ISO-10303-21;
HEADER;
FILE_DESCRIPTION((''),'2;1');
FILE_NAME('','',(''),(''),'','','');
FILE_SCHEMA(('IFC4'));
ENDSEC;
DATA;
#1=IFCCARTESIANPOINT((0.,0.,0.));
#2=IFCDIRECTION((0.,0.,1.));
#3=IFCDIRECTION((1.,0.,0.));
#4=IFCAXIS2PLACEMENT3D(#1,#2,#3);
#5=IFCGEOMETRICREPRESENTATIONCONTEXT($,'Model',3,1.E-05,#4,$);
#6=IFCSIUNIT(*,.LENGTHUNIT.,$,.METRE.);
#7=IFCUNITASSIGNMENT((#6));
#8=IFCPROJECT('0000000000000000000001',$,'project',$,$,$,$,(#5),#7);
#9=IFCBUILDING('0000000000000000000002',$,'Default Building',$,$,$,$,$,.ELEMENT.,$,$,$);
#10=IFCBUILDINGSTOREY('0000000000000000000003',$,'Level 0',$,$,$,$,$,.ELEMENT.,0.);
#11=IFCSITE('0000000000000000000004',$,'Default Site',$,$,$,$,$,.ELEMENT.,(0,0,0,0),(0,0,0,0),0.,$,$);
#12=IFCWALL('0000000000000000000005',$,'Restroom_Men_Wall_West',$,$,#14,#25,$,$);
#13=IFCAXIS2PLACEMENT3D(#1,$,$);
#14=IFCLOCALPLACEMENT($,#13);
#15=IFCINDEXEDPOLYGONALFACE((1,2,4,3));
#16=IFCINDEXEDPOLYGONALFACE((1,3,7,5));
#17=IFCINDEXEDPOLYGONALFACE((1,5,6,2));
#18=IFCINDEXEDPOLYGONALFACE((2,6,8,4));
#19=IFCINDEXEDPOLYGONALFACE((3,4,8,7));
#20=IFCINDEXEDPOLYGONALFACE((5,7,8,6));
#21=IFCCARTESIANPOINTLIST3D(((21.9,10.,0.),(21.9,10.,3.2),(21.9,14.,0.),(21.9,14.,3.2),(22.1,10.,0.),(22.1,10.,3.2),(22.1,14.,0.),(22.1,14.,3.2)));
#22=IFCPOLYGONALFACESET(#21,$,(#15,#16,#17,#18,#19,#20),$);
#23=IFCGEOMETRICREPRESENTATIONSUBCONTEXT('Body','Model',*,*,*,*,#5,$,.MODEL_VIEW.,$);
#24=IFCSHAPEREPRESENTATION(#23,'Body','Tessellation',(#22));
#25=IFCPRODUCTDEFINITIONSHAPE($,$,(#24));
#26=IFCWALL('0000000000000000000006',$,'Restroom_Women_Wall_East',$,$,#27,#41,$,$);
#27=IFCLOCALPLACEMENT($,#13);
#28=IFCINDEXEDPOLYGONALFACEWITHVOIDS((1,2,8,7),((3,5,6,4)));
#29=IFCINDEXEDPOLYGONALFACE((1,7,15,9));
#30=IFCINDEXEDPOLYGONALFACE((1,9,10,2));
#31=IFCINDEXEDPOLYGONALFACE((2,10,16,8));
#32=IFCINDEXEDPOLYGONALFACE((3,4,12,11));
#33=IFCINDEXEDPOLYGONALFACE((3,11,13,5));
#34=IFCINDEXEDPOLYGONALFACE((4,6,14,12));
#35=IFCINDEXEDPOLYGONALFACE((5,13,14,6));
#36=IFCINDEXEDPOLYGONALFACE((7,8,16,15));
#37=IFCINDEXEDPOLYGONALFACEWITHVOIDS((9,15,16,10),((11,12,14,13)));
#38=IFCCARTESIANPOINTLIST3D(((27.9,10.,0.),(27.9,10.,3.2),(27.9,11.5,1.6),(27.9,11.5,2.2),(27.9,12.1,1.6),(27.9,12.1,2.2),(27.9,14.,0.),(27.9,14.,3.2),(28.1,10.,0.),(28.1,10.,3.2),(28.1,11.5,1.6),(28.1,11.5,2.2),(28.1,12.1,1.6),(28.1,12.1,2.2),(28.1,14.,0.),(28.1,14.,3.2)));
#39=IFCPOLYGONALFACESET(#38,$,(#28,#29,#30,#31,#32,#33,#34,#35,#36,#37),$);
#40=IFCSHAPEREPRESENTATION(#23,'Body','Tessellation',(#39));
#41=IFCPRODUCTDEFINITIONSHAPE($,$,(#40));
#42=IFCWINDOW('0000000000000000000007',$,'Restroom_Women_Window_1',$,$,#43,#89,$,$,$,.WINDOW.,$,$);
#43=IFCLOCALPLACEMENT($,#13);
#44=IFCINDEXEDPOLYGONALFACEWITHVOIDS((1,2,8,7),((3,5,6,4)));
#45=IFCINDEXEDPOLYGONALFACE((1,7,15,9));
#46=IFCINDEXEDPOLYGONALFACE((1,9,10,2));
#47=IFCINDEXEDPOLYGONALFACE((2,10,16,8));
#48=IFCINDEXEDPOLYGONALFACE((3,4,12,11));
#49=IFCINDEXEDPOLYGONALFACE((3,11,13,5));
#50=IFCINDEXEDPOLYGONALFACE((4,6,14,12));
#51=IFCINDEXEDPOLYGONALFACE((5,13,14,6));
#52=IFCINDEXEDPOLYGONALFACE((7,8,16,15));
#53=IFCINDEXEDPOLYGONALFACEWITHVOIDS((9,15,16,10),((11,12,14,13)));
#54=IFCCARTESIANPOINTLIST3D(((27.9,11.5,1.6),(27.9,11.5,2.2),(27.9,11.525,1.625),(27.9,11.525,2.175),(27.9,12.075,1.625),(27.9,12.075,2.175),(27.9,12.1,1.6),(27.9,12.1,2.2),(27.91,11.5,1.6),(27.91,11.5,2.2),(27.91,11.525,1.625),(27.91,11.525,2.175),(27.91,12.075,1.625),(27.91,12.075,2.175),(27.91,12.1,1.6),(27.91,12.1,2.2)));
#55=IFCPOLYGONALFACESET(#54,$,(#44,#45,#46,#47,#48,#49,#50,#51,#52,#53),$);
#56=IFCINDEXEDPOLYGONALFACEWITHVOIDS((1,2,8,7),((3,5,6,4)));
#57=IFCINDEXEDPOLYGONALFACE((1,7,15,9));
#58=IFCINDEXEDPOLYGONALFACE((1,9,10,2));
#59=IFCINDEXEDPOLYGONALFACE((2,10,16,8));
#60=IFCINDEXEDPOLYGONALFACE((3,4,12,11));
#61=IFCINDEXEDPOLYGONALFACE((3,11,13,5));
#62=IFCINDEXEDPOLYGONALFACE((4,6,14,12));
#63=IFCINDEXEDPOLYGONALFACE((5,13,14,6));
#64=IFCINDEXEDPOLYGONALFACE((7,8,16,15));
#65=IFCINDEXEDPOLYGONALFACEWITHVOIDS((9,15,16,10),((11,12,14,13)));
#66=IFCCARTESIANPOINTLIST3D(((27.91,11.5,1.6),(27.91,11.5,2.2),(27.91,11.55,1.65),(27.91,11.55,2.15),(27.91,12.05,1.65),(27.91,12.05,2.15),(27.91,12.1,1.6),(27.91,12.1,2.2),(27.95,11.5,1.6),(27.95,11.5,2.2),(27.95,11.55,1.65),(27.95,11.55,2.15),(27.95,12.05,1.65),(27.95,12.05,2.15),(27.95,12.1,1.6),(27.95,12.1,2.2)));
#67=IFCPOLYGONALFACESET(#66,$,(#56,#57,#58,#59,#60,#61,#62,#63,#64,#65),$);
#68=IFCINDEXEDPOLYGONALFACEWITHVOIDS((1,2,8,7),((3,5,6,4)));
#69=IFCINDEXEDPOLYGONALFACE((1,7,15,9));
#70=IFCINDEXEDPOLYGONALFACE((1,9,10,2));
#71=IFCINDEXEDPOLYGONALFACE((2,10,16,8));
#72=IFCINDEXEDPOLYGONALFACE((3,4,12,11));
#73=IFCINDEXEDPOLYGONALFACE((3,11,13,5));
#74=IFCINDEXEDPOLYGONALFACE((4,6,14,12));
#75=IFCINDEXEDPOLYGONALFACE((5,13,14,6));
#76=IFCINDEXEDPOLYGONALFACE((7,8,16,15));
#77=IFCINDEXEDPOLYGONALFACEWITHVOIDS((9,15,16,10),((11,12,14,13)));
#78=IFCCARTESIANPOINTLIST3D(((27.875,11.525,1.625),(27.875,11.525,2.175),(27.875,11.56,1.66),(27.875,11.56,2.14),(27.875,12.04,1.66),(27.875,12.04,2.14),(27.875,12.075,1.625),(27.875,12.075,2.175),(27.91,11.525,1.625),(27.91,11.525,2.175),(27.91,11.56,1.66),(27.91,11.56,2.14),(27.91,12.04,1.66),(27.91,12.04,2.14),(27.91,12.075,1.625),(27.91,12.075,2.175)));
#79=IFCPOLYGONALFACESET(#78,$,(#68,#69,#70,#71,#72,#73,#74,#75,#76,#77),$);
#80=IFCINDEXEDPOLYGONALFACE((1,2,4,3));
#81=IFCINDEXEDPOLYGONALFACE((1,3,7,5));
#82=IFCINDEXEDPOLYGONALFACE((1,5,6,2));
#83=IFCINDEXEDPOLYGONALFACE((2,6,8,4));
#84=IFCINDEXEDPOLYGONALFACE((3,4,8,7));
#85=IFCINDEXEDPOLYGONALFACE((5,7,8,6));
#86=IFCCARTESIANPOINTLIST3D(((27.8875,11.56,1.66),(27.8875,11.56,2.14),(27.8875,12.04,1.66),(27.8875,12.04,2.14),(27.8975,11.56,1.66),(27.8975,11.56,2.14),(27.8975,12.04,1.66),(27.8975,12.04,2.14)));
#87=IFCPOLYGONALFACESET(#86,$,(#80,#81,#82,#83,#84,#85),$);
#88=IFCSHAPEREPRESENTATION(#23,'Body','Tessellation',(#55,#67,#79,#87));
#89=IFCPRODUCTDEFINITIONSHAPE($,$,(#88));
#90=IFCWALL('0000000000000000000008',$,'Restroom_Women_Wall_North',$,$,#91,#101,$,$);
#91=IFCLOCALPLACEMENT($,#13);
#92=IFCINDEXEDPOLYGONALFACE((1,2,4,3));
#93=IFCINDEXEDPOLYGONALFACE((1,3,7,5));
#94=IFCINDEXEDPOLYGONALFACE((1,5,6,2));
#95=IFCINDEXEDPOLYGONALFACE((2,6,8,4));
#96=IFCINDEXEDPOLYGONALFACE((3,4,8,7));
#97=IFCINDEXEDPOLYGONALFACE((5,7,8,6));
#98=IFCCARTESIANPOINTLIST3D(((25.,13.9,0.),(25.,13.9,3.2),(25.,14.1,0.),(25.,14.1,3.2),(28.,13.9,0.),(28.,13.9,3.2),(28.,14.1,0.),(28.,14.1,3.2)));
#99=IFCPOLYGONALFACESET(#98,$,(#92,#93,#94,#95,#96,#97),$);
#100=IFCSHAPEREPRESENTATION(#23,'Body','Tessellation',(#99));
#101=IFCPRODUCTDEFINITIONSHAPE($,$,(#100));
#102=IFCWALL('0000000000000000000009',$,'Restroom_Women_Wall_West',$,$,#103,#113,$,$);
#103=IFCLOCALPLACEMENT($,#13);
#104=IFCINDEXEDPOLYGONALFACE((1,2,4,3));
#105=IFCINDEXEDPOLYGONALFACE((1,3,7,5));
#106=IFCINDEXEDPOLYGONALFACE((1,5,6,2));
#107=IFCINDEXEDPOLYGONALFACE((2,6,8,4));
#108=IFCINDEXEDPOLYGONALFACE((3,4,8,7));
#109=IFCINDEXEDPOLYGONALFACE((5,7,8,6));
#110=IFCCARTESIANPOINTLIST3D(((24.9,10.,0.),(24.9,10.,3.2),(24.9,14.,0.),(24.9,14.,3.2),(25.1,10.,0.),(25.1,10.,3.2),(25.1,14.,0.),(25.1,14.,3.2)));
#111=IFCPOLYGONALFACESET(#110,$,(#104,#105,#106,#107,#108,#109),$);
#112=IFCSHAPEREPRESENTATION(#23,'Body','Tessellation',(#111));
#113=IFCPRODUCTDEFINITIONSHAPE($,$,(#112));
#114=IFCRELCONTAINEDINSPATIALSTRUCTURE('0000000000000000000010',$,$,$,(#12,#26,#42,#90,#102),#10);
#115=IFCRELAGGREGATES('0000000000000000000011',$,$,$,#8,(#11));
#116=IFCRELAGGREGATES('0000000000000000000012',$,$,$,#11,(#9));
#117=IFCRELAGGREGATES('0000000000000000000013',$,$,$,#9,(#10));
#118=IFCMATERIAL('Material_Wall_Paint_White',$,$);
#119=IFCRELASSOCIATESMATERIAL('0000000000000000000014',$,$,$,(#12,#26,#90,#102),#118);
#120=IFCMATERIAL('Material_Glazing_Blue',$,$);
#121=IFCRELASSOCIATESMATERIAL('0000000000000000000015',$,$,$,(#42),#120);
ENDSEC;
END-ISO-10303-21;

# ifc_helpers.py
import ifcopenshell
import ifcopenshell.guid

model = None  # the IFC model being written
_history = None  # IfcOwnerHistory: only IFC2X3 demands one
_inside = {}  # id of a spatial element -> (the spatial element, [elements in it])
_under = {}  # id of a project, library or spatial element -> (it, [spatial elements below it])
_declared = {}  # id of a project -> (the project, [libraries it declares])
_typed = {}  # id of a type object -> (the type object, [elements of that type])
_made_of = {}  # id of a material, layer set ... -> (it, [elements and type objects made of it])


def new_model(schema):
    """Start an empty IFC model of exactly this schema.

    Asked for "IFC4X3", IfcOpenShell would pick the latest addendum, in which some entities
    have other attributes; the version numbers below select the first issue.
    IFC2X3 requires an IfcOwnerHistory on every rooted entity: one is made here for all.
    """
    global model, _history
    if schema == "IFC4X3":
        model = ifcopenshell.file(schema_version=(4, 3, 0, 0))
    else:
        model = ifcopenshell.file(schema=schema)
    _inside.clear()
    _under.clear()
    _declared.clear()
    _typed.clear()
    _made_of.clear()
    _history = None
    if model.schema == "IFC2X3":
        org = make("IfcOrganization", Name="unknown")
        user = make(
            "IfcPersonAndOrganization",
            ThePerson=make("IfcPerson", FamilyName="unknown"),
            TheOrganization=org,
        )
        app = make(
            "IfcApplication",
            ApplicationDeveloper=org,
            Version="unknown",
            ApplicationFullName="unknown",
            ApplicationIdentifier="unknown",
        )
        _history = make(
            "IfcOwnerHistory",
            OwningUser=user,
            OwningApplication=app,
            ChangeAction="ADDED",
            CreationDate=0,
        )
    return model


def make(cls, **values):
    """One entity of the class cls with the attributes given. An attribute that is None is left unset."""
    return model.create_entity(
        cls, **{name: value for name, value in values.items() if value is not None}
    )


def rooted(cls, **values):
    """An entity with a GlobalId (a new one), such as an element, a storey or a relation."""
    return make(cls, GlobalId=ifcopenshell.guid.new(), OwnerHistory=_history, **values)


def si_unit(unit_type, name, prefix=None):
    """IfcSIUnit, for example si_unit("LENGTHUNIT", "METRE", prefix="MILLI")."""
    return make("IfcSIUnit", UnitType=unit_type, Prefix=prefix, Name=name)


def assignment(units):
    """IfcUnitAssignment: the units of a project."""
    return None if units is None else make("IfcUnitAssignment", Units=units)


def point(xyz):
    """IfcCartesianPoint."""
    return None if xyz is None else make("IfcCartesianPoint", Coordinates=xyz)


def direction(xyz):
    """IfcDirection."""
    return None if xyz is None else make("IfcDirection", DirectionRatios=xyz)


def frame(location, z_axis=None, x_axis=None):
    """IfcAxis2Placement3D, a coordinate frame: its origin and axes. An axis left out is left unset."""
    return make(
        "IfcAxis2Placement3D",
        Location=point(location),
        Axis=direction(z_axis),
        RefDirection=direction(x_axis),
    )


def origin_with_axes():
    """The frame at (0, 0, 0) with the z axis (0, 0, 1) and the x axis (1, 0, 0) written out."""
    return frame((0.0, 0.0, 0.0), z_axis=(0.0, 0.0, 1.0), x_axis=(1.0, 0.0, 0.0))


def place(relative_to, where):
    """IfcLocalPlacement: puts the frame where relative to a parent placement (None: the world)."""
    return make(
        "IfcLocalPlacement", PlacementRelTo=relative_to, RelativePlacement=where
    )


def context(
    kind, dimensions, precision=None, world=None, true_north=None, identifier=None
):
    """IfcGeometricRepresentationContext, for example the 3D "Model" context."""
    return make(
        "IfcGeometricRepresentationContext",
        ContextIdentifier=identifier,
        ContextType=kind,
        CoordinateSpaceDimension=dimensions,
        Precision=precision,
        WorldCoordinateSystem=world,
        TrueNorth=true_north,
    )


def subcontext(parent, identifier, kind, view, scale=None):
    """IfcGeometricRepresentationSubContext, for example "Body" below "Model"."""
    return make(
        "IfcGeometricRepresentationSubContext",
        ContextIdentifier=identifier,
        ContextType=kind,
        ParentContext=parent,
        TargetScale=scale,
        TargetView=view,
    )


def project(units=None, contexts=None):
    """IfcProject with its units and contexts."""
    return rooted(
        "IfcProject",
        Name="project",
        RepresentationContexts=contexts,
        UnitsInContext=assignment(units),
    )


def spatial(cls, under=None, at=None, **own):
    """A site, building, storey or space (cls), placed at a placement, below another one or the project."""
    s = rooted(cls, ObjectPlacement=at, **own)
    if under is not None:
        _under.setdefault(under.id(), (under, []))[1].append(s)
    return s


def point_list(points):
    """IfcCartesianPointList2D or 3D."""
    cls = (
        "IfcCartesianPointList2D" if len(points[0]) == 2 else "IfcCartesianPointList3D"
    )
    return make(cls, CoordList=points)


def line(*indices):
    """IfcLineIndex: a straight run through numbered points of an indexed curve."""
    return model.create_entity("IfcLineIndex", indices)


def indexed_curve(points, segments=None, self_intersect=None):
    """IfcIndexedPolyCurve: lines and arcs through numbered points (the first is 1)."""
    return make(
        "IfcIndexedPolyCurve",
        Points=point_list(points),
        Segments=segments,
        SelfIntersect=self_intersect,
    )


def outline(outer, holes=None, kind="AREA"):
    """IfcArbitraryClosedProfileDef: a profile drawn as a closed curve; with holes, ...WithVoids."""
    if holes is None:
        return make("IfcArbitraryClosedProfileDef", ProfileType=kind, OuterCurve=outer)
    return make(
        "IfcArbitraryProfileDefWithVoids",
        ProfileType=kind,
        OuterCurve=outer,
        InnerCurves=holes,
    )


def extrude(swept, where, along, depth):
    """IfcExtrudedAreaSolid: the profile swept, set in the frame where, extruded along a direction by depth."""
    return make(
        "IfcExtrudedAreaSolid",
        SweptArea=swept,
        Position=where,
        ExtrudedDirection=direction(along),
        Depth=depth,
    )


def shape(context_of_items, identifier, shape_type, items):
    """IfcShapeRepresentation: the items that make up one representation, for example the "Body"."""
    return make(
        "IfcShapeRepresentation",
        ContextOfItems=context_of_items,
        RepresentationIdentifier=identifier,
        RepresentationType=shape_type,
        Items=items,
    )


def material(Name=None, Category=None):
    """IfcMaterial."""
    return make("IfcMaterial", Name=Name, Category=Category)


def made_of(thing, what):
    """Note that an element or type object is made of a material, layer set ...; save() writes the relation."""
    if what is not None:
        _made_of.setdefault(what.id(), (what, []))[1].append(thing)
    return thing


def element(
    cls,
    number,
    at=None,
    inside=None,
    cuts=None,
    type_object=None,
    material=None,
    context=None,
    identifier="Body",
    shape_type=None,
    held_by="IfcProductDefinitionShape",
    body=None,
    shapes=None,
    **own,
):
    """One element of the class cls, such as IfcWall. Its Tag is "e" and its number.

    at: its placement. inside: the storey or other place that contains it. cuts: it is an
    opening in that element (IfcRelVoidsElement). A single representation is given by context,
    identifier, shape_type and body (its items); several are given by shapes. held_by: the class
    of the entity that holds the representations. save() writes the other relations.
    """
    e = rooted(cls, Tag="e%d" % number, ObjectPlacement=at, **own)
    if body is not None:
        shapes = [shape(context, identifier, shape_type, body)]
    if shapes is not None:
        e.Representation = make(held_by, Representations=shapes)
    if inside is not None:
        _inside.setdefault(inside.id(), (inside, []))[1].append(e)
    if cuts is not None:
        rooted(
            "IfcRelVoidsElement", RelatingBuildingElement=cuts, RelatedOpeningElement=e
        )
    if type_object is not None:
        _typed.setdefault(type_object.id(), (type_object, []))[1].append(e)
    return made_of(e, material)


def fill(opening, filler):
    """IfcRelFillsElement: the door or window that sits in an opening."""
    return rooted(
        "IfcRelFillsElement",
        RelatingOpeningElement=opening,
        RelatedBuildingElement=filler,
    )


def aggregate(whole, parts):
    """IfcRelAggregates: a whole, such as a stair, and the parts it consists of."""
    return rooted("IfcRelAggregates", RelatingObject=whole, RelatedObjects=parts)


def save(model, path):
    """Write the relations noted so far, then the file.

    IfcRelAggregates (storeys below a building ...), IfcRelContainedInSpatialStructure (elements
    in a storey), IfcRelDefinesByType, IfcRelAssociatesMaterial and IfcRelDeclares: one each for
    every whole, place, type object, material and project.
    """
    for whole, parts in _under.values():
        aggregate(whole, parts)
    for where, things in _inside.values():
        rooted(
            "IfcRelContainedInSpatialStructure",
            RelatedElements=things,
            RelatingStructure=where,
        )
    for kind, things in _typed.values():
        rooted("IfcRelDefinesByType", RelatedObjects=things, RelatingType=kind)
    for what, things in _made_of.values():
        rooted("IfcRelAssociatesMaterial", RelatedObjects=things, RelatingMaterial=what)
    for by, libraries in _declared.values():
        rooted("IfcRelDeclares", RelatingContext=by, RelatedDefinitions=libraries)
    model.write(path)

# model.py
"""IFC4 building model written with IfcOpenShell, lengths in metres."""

from ifc_helpers import new_model, si_unit, frame, origin_with_axes, place, context, subcontext, project, spatial, line, indexed_curve, outline, extrude, material, element, fill, save


model = new_model("IFC4")

# Units and contexts
model_context = context("Model", 3, precision=1e-05, world=origin_with_axes())
body_context = subcontext(model_context, "Body", "Model", "MODEL_VIEW")
ifc_project = project(units=[si_unit("LENGTHUNIT", "METRE")], contexts=[model_context])

# Site, building, storey
site = spatial("IfcSite", under=ifc_project, Name="Default Site", CompositionType="ELEMENT", RefLatitude=(0, 0, 0, 0), RefLongitude=(0, 0, 0, 0), RefElevation=0.0)
building = spatial("IfcBuilding", under=site, Name="Default Building", CompositionType="ELEMENT")
storey = spatial("IfcBuildingStorey", under=building, Name="Level 0", CompositionType="ELEMENT", Elevation=0.0)

# Shared definitions
ifc_material_1 = material(Name="Material_Wall_Paint_White")

# Shared definitions
ifc_material_2 = material(Name="Material_Glazing_Blue")

# Wall
wall_1_placement = place(None, frame((22.0, 14.0, 0.0), z_axis=(0.0, 0.0, 1.0), x_axis=(0.0, -1.0, 0.0)))
element("IfcWall", 1, at=wall_1_placement, inside=storey, material=ifc_material_1, Name="Restroom_Men_Wall_West", context=body_context, shape_type="SweptSolid", body=[
    extrude(outline(indexed_curve([(0.0, 0.0), (0.0, 0.2), (4.0, 0.2), (4.0, 0.0), (0.0, 0.0)], self_intersect=False)), frame((0.0, -0.1, 0.0), z_axis=(0.0, 0.0, 1.0), x_axis=(1.0, 0.0, 0.0)), (0.0, 0.0, 1.0), 3.2),
])

# Wall, opening, window
wall_2_placement = place(None, frame((28.0, 10.0, 0.0), z_axis=(0.0, 0.0, 1.0), x_axis=(0.0, 1.0, 0.0)))
wall_2 = element("IfcWall", 2, at=wall_2_placement, inside=storey, material=ifc_material_1, Name="Restroom_Women_Wall_East", context=body_context, shape_type="SweptSolid", body=[
    extrude(outline(indexed_curve([(0.0, 0.0), (0.0, 0.2), (4.0, 0.2), (4.0, 0.0), (0.0, 0.0)], self_intersect=False)), frame((0.0, -0.1, 0.0), z_axis=(0.0, 0.0, 1.0), x_axis=(1.0, 0.0, 0.0)), (0.0, 0.0, 1.0), 3.2),
])
opening_1_placement = place(wall_2_placement, frame((1.5, -0.5, 1.6), z_axis=(0.0, 0.0, 1.0), x_axis=(1.0, 0.0, 0.0)))
opening_1 = element("IfcOpeningElement", 3, at=opening_1_placement, inside=storey, cuts=wall_2, PredefinedType="OPENING", context=body_context, shape_type="SweptSolid", body=[
    extrude(outline(indexed_curve([(0.0, 0.0), (0.0, 1.0), (0.6, 1.0), (0.6, 0.0), (0.0, 0.0)], self_intersect=False)), origin_with_axes(), (0.0, 0.0, 1.0), 0.6),
])
window_1_placement = place(None, frame((28.0, 11.5, 1.6), z_axis=(0.0, 0.0, 1.0), x_axis=(0.0, 1.0, 0.0)))
window_1 = element("IfcWindow", 4, at=window_1_placement, inside=storey, material=ifc_material_2, Name="Restroom_Women_Window_1", PredefinedType="WINDOW", context=body_context, shape_type="SweptSolid", body=[
    extrude(outline(indexed_curve([(0.0, 0.0), (0.6, 0.0), (0.6, 0.6), (0.0, 0.6)], segments=[line(1, 2, 3, 4, 1)]), holes=[indexed_curve([(0.025, 0.025), (0.575, 0.025), (0.575, 0.575), (0.025, 0.575)], segments=[line(1, 2, 3, 4, 1)])]), frame((0.0, 0.09, 0.0), z_axis=(0.0, -1.0, 0.0), x_axis=(1.0, 0.0, 0.0)), (0.0, 0.0, -1.0), 0.01),
    extrude(outline(indexed_curve([(0.0, 0.0), (0.6, 0.0), (0.6, 0.6), (0.0, 0.6)], segments=[line(1, 2, 3, 4, 1)]), holes=[indexed_curve([(0.05, 0.05), (0.55, 0.05), (0.55, 0.55), (0.05, 0.55)], segments=[line(1, 2, 3, 4, 1)])]), frame((0.0, 0.05, 0.0), z_axis=(0.0, -1.0, 0.0), x_axis=(1.0, 0.0, 0.0)), (0.0, 0.0, -1.0), 0.04),
    extrude(outline(indexed_curve([(0.0, 0.0), (0.55, 0.0), (0.55, 0.55), (0.0, 0.55)], segments=[line(1, 2, 3, 4, 1)]), holes=[indexed_curve([(0.035, 0.035), (0.515, 0.035), (0.515, 0.515), (0.035, 0.515)], segments=[line(1, 2, 3, 4, 1)])]), frame((0.025, 0.09, 0.025), z_axis=(0.0, -1.0, 0.0), x_axis=(1.0, 0.0, 0.0)), (0.0, 0.0, -1.0), 0.035),
    extrude(outline(indexed_curve([(0.035, 0.035), (0.515, 0.035), (0.515, 0.515), (0.035, 0.515)], segments=[line(1, 2, 3, 4, 1)])), frame((0.025, 0.1025, 0.025), z_axis=(0.0, -1.0, 0.0), x_axis=(1.0, 0.0, 0.0)), (0.0, 0.0, -1.0), 0.01),
])
fill(opening_1, window_1)

# Walls
wall_3_placement = place(None, frame((28.0, 14.0, 0.0), z_axis=(0.0, 0.0, 1.0), x_axis=(-1.0, 0.0, 0.0)))
element("IfcWall", 5, at=wall_3_placement, inside=storey, material=ifc_material_1, Name="Restroom_Women_Wall_North", context=body_context, shape_type="SweptSolid", body=[
    extrude(outline(indexed_curve([(0.0, 0.0), (0.0, 0.2), (3.0, 0.2), (3.0, 0.0), (0.0, 0.0)], self_intersect=False)), frame((0.0, -0.1, 0.0), z_axis=(0.0, 0.0, 1.0), x_axis=(1.0, 0.0, 0.0)), (0.0, 0.0, 1.0), 3.2),
])
wall_4_placement = place(None, frame((25.0, 14.0, 0.0), z_axis=(0.0, 0.0, 1.0), x_axis=(0.0, -1.0, 0.0)))
element("IfcWall", 6, at=wall_4_placement, inside=storey, material=ifc_material_1, Name="Restroom_Women_Wall_West", context=body_context, shape_type="SweptSolid", body=[
    extrude(outline(indexed_curve([(0.0, 0.0), (0.0, 0.2), (4.0, 0.2), (4.0, 0.0), (0.0, 0.0)], self_intersect=False)), frame((0.0, -0.1, 0.0), z_axis=(0.0, 0.0, 1.0), x_axis=(1.0, 0.0, 0.0)), (0.0, 0.0, 1.0), 3.2),
])

save(model, "model.ifc")
